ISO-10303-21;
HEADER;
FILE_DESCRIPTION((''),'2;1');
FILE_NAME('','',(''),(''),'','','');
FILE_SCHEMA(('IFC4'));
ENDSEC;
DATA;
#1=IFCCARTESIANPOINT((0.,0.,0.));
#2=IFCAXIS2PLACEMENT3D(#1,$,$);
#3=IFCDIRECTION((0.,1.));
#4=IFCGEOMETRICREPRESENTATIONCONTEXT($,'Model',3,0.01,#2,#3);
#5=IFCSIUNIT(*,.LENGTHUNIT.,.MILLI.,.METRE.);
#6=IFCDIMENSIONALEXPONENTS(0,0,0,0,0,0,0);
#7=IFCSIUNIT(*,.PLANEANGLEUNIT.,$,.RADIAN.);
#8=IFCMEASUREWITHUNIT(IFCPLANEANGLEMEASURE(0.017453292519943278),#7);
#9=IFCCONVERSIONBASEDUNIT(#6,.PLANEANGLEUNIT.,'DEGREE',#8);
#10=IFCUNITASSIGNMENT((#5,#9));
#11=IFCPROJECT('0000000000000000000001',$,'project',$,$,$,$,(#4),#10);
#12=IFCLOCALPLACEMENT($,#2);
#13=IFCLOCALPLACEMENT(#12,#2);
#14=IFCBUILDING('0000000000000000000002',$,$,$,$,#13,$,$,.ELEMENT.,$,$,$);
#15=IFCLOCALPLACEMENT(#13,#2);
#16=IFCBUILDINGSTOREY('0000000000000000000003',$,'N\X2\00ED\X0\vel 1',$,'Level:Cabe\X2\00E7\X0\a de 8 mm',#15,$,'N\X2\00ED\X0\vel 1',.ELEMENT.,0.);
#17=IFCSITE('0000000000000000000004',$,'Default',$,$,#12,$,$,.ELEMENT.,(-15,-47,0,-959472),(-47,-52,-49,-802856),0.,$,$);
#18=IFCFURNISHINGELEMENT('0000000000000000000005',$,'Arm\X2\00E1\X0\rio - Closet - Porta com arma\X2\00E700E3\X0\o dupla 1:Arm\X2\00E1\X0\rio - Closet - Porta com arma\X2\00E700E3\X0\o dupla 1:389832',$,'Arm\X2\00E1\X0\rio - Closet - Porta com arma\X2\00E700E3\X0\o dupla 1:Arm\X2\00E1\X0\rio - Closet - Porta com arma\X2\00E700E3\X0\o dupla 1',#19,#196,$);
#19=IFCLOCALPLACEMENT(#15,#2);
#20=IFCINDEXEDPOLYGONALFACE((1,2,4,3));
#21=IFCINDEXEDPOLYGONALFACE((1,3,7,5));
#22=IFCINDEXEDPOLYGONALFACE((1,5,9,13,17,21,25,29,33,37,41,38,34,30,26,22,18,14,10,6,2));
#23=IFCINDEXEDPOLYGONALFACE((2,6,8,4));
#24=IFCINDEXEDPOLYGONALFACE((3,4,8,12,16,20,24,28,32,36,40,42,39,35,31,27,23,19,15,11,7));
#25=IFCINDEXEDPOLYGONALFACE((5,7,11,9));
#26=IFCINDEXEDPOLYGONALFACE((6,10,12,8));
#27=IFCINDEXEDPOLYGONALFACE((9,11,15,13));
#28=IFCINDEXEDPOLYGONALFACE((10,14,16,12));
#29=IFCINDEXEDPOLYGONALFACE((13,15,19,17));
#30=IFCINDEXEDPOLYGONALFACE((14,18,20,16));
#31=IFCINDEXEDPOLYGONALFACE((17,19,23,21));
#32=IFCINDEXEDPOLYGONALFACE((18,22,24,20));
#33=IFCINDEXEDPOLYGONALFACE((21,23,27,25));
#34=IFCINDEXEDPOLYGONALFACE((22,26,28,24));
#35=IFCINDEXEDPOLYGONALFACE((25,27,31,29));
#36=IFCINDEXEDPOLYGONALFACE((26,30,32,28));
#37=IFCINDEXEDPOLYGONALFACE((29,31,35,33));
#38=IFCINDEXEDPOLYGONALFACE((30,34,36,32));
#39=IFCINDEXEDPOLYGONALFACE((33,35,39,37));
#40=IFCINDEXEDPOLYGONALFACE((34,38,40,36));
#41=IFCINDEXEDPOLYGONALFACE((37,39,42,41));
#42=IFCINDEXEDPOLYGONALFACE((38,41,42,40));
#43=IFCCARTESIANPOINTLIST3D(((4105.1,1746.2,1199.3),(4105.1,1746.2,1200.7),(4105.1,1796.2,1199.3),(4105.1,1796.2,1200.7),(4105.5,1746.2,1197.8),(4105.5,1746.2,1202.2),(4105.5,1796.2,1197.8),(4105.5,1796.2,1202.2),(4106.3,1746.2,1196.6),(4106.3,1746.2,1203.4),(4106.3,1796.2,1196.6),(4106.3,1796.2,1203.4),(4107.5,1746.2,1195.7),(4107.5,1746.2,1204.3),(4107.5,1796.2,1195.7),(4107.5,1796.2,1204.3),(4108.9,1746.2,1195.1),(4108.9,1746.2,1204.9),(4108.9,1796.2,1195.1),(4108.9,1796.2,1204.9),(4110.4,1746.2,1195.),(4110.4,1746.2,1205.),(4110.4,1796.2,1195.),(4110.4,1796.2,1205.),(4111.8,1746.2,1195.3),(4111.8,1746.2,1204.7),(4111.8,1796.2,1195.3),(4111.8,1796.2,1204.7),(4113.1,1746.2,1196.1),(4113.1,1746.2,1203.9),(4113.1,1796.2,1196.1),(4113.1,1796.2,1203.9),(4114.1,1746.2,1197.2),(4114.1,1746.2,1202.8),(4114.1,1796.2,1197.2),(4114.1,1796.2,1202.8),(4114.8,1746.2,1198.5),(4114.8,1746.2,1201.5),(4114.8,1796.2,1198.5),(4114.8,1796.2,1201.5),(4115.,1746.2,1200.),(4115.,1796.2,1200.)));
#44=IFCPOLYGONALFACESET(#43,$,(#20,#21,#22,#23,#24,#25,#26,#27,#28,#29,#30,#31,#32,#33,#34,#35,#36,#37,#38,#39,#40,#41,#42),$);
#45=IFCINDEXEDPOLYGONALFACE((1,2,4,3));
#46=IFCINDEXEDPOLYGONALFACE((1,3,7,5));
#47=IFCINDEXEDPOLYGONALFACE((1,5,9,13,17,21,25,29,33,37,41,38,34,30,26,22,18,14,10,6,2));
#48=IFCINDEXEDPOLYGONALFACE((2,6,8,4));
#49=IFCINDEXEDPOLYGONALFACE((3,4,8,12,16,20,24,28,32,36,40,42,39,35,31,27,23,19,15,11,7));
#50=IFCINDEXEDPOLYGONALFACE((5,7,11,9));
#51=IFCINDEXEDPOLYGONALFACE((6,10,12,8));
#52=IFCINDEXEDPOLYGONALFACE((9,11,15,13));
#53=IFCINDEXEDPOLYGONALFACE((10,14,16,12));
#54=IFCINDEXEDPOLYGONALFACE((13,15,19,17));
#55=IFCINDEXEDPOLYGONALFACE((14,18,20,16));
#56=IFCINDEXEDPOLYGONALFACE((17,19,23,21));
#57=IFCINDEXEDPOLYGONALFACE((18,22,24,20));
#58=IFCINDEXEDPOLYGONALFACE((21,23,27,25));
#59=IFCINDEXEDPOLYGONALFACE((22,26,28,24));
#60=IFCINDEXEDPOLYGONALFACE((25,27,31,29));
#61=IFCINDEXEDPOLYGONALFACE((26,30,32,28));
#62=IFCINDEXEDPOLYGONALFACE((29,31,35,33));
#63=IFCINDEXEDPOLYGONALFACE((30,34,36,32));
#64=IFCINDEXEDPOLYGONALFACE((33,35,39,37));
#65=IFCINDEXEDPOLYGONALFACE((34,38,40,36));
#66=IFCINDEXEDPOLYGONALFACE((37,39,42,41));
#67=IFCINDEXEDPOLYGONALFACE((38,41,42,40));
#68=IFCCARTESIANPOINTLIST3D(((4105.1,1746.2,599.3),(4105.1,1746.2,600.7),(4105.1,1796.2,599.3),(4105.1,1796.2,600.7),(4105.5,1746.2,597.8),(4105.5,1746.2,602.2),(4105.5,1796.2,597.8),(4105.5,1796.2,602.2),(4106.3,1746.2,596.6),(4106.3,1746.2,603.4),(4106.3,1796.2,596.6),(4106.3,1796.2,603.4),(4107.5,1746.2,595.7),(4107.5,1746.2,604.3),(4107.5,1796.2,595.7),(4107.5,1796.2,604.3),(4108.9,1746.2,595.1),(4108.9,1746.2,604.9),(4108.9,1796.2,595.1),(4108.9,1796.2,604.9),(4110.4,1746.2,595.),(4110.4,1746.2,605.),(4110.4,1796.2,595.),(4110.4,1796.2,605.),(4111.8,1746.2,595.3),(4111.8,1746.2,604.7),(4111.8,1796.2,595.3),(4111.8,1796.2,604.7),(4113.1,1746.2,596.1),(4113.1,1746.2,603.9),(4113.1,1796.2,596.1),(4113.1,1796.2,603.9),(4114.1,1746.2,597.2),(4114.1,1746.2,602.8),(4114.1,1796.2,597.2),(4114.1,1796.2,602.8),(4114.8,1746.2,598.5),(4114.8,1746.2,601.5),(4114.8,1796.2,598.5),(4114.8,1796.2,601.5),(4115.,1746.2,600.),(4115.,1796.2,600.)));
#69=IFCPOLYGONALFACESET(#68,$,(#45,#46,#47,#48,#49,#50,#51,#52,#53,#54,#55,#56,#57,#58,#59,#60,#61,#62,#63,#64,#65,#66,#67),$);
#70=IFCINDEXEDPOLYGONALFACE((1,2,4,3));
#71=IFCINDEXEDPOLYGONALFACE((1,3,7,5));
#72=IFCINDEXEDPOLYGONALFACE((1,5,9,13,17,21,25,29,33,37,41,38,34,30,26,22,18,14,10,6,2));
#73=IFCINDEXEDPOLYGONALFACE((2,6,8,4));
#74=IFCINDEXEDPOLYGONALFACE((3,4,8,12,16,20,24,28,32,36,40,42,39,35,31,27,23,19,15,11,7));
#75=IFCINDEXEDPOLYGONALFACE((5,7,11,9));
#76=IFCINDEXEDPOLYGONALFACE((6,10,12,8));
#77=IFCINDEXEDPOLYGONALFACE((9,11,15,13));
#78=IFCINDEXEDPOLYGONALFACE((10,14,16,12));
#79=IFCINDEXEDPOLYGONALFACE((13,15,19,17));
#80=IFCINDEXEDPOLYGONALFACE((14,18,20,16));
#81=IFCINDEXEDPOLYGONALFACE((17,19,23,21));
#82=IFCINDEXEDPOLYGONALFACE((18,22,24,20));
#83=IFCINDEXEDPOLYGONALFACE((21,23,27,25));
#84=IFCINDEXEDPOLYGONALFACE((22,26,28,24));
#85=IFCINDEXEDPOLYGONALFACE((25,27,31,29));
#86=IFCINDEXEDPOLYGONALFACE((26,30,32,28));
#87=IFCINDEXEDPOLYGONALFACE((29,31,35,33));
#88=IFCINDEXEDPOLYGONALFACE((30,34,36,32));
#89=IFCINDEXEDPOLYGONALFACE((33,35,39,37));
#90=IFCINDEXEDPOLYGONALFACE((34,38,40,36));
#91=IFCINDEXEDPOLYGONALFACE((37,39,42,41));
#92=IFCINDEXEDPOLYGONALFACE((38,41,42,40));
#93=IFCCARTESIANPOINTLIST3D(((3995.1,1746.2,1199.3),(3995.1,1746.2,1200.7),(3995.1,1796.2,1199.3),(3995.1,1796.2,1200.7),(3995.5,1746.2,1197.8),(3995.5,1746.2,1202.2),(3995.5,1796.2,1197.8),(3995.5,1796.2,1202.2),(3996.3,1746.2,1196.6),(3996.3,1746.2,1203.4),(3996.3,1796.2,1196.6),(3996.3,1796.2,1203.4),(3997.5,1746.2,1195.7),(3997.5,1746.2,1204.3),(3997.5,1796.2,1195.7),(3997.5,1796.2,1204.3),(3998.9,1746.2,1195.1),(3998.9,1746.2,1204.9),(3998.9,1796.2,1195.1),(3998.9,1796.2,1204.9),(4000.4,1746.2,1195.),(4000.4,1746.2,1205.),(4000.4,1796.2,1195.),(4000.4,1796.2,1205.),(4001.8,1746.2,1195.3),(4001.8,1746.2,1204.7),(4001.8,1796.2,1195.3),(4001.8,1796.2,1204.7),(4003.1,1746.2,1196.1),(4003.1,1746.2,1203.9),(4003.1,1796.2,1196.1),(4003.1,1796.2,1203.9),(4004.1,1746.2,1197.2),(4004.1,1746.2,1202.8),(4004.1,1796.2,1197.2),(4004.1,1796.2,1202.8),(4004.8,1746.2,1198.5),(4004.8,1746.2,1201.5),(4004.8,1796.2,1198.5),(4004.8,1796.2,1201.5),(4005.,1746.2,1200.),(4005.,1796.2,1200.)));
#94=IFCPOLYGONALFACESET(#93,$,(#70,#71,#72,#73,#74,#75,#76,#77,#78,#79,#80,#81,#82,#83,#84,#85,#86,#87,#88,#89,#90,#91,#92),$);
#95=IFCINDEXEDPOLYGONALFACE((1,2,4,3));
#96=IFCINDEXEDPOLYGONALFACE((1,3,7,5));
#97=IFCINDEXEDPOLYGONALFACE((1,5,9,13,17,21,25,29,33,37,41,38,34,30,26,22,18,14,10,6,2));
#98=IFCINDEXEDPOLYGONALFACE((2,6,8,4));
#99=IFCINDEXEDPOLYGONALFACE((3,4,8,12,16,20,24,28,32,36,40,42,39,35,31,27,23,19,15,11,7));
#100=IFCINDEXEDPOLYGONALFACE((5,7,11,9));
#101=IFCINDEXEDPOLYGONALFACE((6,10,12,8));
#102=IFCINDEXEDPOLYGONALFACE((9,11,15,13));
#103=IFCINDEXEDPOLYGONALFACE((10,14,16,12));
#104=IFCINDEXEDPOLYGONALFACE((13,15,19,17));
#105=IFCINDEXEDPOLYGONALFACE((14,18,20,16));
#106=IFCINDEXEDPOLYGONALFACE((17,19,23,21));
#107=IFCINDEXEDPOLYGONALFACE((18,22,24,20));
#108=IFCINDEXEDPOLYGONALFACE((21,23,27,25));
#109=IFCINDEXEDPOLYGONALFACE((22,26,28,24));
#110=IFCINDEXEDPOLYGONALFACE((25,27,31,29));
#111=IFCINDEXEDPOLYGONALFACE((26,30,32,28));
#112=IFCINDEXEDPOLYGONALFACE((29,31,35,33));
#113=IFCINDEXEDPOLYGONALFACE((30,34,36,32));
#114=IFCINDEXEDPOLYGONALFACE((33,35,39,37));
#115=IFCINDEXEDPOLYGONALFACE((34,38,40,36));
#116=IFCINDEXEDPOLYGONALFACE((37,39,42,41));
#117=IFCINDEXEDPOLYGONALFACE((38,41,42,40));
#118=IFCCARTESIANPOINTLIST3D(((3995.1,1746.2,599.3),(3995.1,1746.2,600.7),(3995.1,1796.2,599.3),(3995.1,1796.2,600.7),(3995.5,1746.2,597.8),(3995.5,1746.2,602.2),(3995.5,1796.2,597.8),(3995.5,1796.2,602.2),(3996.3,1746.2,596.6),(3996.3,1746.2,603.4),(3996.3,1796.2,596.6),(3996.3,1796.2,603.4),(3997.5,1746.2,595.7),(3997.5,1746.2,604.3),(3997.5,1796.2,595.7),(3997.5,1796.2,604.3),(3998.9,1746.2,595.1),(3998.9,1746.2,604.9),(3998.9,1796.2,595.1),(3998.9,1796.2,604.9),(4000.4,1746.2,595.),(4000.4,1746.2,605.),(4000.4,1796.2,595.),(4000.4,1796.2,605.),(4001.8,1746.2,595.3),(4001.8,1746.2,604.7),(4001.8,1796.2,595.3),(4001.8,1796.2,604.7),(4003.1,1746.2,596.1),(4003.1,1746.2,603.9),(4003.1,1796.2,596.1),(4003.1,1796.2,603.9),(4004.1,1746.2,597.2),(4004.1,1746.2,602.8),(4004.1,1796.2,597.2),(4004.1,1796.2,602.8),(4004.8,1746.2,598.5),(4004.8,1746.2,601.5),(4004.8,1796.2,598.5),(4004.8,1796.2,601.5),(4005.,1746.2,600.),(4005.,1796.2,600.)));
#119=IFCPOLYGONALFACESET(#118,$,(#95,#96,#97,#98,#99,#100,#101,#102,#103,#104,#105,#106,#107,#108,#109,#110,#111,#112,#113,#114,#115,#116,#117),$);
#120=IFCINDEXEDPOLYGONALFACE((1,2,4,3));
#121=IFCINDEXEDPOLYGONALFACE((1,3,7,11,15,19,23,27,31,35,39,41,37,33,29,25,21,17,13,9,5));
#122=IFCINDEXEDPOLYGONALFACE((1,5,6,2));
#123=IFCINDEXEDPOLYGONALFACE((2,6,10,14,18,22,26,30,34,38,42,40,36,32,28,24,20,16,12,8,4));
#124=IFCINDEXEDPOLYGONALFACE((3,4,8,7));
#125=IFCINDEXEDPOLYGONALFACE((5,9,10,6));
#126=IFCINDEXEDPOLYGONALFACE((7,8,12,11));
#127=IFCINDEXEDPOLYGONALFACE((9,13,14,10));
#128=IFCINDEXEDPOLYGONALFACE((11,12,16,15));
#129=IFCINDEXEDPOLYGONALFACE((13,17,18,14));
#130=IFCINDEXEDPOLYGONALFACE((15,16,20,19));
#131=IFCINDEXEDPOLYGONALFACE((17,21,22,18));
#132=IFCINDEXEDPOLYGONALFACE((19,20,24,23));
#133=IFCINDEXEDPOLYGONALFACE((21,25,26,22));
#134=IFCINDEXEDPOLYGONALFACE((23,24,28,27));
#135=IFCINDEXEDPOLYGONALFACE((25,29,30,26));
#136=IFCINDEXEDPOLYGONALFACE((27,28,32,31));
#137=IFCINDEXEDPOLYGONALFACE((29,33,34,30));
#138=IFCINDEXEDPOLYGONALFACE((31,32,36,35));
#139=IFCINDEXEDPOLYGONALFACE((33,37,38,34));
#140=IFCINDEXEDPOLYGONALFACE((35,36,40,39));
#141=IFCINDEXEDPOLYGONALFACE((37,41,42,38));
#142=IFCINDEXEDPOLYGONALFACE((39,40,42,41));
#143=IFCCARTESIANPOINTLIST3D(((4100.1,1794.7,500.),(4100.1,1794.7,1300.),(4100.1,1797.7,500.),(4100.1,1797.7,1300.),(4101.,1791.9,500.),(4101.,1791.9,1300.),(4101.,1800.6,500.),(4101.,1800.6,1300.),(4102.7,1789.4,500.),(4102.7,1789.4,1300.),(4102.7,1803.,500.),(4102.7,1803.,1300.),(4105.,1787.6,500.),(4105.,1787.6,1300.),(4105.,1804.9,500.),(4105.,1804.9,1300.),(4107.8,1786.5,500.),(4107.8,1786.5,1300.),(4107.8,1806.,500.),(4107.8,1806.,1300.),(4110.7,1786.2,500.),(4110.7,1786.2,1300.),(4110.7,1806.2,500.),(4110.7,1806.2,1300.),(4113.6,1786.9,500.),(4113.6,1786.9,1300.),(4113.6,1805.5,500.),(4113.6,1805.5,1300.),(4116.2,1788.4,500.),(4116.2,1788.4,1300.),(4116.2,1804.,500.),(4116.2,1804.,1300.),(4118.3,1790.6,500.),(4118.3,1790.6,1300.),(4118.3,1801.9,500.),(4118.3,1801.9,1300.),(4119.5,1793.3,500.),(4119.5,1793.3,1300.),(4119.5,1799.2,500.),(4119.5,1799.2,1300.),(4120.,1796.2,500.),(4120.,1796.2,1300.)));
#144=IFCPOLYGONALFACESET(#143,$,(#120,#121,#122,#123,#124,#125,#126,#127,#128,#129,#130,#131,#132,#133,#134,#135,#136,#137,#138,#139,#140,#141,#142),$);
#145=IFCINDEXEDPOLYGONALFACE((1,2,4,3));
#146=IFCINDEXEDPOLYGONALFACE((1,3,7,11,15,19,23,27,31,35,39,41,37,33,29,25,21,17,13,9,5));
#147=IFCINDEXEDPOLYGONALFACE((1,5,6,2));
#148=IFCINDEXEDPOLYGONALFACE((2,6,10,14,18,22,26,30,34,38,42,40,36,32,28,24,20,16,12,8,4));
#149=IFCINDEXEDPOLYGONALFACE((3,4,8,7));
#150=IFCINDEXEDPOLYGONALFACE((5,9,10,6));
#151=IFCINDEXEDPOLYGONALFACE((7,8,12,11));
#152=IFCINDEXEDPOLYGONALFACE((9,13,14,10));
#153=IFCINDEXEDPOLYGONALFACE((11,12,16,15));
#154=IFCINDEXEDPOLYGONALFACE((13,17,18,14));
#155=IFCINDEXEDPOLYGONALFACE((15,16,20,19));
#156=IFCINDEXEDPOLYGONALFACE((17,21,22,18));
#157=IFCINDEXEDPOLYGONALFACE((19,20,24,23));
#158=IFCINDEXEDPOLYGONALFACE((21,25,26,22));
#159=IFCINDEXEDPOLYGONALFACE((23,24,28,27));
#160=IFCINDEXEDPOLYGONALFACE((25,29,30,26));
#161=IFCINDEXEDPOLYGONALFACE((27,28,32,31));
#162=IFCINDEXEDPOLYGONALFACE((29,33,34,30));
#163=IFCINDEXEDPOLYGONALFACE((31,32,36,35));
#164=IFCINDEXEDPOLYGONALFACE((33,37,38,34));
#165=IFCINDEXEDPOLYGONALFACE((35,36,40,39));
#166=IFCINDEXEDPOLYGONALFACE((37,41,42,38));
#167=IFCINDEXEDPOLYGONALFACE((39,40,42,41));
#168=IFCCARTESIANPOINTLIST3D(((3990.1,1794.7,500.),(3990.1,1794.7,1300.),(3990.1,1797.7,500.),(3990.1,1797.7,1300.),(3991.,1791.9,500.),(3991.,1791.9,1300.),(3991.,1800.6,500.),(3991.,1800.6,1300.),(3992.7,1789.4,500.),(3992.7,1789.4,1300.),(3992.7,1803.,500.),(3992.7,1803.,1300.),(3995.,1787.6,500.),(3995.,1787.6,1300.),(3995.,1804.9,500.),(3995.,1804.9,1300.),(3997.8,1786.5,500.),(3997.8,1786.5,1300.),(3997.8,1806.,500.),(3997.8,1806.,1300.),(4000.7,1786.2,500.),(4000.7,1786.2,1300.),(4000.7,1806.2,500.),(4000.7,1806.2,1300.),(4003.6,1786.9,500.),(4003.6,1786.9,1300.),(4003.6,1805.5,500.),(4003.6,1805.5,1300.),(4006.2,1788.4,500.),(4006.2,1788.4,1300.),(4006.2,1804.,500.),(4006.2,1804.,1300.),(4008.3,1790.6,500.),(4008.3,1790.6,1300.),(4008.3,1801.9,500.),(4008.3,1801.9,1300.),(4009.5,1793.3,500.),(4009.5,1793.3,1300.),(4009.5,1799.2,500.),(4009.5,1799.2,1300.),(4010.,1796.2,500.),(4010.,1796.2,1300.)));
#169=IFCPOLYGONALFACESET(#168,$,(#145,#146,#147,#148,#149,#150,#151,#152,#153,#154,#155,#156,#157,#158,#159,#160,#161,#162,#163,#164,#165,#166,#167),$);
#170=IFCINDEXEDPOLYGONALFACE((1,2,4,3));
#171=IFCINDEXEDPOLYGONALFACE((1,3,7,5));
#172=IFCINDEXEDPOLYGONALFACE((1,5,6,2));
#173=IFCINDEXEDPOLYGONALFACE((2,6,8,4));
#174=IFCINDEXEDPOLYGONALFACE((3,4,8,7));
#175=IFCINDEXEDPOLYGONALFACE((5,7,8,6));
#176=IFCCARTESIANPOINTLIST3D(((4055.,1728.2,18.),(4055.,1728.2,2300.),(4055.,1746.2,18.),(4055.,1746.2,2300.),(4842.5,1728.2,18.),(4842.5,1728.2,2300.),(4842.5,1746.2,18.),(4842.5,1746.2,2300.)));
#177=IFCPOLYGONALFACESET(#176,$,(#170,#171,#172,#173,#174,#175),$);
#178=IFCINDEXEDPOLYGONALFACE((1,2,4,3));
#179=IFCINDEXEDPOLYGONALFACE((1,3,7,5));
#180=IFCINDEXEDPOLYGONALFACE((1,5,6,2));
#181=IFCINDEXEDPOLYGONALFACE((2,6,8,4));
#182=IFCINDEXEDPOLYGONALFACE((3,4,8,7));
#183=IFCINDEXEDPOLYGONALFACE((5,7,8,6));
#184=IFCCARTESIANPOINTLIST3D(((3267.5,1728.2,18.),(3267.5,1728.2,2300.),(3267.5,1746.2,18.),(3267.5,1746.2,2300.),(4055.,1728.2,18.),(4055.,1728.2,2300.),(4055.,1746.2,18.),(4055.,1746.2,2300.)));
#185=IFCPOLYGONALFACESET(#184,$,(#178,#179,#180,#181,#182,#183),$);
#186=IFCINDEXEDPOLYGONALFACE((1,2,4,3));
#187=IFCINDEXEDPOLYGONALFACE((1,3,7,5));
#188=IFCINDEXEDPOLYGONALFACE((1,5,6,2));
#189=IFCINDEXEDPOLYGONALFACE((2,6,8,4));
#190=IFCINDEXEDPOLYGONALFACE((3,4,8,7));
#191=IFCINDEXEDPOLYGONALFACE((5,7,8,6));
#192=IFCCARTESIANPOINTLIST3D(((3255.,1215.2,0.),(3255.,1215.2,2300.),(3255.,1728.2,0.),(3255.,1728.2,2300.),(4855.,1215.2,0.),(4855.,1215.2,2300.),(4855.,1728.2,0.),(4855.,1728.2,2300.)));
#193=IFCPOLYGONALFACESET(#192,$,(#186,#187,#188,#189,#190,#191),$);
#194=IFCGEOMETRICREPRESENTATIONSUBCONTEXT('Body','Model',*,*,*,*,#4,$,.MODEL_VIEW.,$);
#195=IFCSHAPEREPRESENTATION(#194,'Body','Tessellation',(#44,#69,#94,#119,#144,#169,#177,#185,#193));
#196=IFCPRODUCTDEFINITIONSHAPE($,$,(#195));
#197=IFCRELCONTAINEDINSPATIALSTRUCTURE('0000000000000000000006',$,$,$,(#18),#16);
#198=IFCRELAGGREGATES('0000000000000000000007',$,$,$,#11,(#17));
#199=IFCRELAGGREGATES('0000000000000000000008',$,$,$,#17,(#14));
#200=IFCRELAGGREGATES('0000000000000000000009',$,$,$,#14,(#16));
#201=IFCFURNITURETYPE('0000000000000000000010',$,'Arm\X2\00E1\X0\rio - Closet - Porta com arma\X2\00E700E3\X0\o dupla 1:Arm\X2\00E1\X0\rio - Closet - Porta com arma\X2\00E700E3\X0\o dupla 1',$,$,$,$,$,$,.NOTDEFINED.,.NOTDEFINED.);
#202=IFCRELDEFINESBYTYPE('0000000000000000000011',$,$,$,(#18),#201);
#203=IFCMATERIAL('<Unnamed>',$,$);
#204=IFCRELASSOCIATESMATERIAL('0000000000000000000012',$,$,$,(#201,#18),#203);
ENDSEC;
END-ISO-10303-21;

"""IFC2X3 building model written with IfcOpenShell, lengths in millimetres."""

from ifc_helpers import new_model, entity, si_unit, converted_unit, direction, frame, origin, origin_2d_with_axis, place, context, subcontext, project, spatial, rectangle, circle, extrude, source, transform, mapped, material, type_object, type_shapes, element, save


model = new_model("IFC2X3")

# Units and contexts
model_context = context("Model", 3, precision=0.01, world=origin(), true_north=direction((0.0, 1.0)))
body_context = subcontext(model_context, "Body", "Model", "MODEL_VIEW")
ifc_project = project(units=[si_unit("LENGTHUNIT", "METRE", prefix="MILLI"), converted_unit("PLANEANGLEUNIT", "DEGREE", entity("IfcPlaneAngleMeasure", 0.017453292519943278), si_unit("PLANEANGLEUNIT", "RADIAN"), dimensions=[0, 0, 0, 0, 0, 0, 0])], contexts=[model_context])

# Site, building, storey
site_placement = place(None, origin())
site = spatial("IfcSite", under=ifc_project, at=site_placement, Name="Default", CompositionType="ELEMENT", RefLatitude=(-15, -47, 0, -959472), RefLongitude=(-47, -52, -49, -802856), RefElevation=0.0)
building_placement = place(site_placement, origin())
building = spatial("IfcBuilding", under=site, at=building_placement, CompositionType="ELEMENT")
storey_placement = place(building_placement, origin())
storey = spatial("IfcBuildingStorey", under=building, at=storey_placement, Name="Nível 1", ObjectType="Level:Cabeça de 8 mm", LongName="Nível 1", CompositionType="ELEMENT", Elevation=0.0)

# Shared definitions
ifc_material_1 = material(Name="<Unnamed>")

# Furnishing element
furniture_type = type_object("IfcFurnitureType", Name="Armário - Closet - Porta com armação dupla 1:Armário - Closet - Porta com armação dupla 1", AssemblyPlace="NOTDEFINED", material=ifc_material_1)
shared_shape_1 = source(origin(), body_context, "Body", "SweptSolid", [
    extrude(circle(Radius=5.0, at=origin_2d_with_axis()), frame((55.0, 531.0, 1200.0), z_axis=(0.0, 1.0, 0.0), x_axis=(1.0, 0.0, 0.0)), (0.0, 0.0, 1.0), 50.0),
    extrude(circle(Radius=5.0, at=origin_2d_with_axis()), frame((55.0, 531.0, 600.0), z_axis=(0.0, 1.0, 0.0), x_axis=(1.0, 0.0, 0.0)), (0.0, 0.0, 1.0), 50.0),
    extrude(circle(Radius=5.0, at=origin_2d_with_axis()), frame((-55.0, 531.0, 1200.0), z_axis=(0.0, 1.0, 0.0), x_axis=(1.0, 0.0, 0.0)), (0.0, 0.0, 1.0), 50.0),
    extrude(circle(Radius=5.0, at=origin_2d_with_axis()), frame((-55.0, 531.0, 600.0), z_axis=(0.0, 1.0, 0.0), x_axis=(1.0, 0.0, 0.0)), (0.0, 0.0, 1.0), 50.0),
    extrude(circle(Radius=10.0, at=origin_2d_with_axis()), frame((55.0, 581.0, 500.0)), (0.0, 0.0, 1.0), 800.0),
    extrude(circle(Radius=10.0, at=origin_2d_with_axis()), frame((-55.0, 581.0, 500.0)), (0.0, 0.0, 1.0), 800.0),
    extrude(rectangle(XDim=787.5, YDim=18.0, at=origin_2d_with_axis()), frame((393.8, 522.0, 18.0)), (0.0, 0.0, 1.0), 2282.0),
    extrude(rectangle(XDim=18.0, YDim=787.5, at=origin_2d_with_axis()), frame((-393.8, 522.0, 18.0), z_axis=(0.0, 0.0, 1.0), x_axis=(0.0, 1.0, 0.0)), (0.0, 0.0, 1.0), 2282.0),
    extrude(rectangle(XDim=513.0, YDim=1600.0, at=origin_2d_with_axis()), frame((0.0, 256.5, 0.0), z_axis=(0.0, 0.0, 1.0), x_axis=(0.0, 1.0, 0.0)), (0.0, 0.0, 1.0), 2300.0),
])
type_shapes(furniture_type, [shared_shape_1])
furnishing_placement = place(storey_placement, frame((4055.0, 1215.2, 0.0)))
element("IfcFurnishingElement", 1, at=furnishing_placement, inside=storey, type_object=furniture_type, material=ifc_material_1, Name="Armário - Closet - Porta com armação dupla 1:Armário - Closet - Porta com armação dupla 1:389832", ObjectType="Armário - Closet - Porta com armação dupla 1:Armário - Closet - Porta com armação dupla 1", context=body_context, shape_type="MappedRepresentation", body=[
    mapped(shared_shape_1, transform((0.0, 0.0, 0.0), scale=1.0)),
])

save(model, "model.ifc")
